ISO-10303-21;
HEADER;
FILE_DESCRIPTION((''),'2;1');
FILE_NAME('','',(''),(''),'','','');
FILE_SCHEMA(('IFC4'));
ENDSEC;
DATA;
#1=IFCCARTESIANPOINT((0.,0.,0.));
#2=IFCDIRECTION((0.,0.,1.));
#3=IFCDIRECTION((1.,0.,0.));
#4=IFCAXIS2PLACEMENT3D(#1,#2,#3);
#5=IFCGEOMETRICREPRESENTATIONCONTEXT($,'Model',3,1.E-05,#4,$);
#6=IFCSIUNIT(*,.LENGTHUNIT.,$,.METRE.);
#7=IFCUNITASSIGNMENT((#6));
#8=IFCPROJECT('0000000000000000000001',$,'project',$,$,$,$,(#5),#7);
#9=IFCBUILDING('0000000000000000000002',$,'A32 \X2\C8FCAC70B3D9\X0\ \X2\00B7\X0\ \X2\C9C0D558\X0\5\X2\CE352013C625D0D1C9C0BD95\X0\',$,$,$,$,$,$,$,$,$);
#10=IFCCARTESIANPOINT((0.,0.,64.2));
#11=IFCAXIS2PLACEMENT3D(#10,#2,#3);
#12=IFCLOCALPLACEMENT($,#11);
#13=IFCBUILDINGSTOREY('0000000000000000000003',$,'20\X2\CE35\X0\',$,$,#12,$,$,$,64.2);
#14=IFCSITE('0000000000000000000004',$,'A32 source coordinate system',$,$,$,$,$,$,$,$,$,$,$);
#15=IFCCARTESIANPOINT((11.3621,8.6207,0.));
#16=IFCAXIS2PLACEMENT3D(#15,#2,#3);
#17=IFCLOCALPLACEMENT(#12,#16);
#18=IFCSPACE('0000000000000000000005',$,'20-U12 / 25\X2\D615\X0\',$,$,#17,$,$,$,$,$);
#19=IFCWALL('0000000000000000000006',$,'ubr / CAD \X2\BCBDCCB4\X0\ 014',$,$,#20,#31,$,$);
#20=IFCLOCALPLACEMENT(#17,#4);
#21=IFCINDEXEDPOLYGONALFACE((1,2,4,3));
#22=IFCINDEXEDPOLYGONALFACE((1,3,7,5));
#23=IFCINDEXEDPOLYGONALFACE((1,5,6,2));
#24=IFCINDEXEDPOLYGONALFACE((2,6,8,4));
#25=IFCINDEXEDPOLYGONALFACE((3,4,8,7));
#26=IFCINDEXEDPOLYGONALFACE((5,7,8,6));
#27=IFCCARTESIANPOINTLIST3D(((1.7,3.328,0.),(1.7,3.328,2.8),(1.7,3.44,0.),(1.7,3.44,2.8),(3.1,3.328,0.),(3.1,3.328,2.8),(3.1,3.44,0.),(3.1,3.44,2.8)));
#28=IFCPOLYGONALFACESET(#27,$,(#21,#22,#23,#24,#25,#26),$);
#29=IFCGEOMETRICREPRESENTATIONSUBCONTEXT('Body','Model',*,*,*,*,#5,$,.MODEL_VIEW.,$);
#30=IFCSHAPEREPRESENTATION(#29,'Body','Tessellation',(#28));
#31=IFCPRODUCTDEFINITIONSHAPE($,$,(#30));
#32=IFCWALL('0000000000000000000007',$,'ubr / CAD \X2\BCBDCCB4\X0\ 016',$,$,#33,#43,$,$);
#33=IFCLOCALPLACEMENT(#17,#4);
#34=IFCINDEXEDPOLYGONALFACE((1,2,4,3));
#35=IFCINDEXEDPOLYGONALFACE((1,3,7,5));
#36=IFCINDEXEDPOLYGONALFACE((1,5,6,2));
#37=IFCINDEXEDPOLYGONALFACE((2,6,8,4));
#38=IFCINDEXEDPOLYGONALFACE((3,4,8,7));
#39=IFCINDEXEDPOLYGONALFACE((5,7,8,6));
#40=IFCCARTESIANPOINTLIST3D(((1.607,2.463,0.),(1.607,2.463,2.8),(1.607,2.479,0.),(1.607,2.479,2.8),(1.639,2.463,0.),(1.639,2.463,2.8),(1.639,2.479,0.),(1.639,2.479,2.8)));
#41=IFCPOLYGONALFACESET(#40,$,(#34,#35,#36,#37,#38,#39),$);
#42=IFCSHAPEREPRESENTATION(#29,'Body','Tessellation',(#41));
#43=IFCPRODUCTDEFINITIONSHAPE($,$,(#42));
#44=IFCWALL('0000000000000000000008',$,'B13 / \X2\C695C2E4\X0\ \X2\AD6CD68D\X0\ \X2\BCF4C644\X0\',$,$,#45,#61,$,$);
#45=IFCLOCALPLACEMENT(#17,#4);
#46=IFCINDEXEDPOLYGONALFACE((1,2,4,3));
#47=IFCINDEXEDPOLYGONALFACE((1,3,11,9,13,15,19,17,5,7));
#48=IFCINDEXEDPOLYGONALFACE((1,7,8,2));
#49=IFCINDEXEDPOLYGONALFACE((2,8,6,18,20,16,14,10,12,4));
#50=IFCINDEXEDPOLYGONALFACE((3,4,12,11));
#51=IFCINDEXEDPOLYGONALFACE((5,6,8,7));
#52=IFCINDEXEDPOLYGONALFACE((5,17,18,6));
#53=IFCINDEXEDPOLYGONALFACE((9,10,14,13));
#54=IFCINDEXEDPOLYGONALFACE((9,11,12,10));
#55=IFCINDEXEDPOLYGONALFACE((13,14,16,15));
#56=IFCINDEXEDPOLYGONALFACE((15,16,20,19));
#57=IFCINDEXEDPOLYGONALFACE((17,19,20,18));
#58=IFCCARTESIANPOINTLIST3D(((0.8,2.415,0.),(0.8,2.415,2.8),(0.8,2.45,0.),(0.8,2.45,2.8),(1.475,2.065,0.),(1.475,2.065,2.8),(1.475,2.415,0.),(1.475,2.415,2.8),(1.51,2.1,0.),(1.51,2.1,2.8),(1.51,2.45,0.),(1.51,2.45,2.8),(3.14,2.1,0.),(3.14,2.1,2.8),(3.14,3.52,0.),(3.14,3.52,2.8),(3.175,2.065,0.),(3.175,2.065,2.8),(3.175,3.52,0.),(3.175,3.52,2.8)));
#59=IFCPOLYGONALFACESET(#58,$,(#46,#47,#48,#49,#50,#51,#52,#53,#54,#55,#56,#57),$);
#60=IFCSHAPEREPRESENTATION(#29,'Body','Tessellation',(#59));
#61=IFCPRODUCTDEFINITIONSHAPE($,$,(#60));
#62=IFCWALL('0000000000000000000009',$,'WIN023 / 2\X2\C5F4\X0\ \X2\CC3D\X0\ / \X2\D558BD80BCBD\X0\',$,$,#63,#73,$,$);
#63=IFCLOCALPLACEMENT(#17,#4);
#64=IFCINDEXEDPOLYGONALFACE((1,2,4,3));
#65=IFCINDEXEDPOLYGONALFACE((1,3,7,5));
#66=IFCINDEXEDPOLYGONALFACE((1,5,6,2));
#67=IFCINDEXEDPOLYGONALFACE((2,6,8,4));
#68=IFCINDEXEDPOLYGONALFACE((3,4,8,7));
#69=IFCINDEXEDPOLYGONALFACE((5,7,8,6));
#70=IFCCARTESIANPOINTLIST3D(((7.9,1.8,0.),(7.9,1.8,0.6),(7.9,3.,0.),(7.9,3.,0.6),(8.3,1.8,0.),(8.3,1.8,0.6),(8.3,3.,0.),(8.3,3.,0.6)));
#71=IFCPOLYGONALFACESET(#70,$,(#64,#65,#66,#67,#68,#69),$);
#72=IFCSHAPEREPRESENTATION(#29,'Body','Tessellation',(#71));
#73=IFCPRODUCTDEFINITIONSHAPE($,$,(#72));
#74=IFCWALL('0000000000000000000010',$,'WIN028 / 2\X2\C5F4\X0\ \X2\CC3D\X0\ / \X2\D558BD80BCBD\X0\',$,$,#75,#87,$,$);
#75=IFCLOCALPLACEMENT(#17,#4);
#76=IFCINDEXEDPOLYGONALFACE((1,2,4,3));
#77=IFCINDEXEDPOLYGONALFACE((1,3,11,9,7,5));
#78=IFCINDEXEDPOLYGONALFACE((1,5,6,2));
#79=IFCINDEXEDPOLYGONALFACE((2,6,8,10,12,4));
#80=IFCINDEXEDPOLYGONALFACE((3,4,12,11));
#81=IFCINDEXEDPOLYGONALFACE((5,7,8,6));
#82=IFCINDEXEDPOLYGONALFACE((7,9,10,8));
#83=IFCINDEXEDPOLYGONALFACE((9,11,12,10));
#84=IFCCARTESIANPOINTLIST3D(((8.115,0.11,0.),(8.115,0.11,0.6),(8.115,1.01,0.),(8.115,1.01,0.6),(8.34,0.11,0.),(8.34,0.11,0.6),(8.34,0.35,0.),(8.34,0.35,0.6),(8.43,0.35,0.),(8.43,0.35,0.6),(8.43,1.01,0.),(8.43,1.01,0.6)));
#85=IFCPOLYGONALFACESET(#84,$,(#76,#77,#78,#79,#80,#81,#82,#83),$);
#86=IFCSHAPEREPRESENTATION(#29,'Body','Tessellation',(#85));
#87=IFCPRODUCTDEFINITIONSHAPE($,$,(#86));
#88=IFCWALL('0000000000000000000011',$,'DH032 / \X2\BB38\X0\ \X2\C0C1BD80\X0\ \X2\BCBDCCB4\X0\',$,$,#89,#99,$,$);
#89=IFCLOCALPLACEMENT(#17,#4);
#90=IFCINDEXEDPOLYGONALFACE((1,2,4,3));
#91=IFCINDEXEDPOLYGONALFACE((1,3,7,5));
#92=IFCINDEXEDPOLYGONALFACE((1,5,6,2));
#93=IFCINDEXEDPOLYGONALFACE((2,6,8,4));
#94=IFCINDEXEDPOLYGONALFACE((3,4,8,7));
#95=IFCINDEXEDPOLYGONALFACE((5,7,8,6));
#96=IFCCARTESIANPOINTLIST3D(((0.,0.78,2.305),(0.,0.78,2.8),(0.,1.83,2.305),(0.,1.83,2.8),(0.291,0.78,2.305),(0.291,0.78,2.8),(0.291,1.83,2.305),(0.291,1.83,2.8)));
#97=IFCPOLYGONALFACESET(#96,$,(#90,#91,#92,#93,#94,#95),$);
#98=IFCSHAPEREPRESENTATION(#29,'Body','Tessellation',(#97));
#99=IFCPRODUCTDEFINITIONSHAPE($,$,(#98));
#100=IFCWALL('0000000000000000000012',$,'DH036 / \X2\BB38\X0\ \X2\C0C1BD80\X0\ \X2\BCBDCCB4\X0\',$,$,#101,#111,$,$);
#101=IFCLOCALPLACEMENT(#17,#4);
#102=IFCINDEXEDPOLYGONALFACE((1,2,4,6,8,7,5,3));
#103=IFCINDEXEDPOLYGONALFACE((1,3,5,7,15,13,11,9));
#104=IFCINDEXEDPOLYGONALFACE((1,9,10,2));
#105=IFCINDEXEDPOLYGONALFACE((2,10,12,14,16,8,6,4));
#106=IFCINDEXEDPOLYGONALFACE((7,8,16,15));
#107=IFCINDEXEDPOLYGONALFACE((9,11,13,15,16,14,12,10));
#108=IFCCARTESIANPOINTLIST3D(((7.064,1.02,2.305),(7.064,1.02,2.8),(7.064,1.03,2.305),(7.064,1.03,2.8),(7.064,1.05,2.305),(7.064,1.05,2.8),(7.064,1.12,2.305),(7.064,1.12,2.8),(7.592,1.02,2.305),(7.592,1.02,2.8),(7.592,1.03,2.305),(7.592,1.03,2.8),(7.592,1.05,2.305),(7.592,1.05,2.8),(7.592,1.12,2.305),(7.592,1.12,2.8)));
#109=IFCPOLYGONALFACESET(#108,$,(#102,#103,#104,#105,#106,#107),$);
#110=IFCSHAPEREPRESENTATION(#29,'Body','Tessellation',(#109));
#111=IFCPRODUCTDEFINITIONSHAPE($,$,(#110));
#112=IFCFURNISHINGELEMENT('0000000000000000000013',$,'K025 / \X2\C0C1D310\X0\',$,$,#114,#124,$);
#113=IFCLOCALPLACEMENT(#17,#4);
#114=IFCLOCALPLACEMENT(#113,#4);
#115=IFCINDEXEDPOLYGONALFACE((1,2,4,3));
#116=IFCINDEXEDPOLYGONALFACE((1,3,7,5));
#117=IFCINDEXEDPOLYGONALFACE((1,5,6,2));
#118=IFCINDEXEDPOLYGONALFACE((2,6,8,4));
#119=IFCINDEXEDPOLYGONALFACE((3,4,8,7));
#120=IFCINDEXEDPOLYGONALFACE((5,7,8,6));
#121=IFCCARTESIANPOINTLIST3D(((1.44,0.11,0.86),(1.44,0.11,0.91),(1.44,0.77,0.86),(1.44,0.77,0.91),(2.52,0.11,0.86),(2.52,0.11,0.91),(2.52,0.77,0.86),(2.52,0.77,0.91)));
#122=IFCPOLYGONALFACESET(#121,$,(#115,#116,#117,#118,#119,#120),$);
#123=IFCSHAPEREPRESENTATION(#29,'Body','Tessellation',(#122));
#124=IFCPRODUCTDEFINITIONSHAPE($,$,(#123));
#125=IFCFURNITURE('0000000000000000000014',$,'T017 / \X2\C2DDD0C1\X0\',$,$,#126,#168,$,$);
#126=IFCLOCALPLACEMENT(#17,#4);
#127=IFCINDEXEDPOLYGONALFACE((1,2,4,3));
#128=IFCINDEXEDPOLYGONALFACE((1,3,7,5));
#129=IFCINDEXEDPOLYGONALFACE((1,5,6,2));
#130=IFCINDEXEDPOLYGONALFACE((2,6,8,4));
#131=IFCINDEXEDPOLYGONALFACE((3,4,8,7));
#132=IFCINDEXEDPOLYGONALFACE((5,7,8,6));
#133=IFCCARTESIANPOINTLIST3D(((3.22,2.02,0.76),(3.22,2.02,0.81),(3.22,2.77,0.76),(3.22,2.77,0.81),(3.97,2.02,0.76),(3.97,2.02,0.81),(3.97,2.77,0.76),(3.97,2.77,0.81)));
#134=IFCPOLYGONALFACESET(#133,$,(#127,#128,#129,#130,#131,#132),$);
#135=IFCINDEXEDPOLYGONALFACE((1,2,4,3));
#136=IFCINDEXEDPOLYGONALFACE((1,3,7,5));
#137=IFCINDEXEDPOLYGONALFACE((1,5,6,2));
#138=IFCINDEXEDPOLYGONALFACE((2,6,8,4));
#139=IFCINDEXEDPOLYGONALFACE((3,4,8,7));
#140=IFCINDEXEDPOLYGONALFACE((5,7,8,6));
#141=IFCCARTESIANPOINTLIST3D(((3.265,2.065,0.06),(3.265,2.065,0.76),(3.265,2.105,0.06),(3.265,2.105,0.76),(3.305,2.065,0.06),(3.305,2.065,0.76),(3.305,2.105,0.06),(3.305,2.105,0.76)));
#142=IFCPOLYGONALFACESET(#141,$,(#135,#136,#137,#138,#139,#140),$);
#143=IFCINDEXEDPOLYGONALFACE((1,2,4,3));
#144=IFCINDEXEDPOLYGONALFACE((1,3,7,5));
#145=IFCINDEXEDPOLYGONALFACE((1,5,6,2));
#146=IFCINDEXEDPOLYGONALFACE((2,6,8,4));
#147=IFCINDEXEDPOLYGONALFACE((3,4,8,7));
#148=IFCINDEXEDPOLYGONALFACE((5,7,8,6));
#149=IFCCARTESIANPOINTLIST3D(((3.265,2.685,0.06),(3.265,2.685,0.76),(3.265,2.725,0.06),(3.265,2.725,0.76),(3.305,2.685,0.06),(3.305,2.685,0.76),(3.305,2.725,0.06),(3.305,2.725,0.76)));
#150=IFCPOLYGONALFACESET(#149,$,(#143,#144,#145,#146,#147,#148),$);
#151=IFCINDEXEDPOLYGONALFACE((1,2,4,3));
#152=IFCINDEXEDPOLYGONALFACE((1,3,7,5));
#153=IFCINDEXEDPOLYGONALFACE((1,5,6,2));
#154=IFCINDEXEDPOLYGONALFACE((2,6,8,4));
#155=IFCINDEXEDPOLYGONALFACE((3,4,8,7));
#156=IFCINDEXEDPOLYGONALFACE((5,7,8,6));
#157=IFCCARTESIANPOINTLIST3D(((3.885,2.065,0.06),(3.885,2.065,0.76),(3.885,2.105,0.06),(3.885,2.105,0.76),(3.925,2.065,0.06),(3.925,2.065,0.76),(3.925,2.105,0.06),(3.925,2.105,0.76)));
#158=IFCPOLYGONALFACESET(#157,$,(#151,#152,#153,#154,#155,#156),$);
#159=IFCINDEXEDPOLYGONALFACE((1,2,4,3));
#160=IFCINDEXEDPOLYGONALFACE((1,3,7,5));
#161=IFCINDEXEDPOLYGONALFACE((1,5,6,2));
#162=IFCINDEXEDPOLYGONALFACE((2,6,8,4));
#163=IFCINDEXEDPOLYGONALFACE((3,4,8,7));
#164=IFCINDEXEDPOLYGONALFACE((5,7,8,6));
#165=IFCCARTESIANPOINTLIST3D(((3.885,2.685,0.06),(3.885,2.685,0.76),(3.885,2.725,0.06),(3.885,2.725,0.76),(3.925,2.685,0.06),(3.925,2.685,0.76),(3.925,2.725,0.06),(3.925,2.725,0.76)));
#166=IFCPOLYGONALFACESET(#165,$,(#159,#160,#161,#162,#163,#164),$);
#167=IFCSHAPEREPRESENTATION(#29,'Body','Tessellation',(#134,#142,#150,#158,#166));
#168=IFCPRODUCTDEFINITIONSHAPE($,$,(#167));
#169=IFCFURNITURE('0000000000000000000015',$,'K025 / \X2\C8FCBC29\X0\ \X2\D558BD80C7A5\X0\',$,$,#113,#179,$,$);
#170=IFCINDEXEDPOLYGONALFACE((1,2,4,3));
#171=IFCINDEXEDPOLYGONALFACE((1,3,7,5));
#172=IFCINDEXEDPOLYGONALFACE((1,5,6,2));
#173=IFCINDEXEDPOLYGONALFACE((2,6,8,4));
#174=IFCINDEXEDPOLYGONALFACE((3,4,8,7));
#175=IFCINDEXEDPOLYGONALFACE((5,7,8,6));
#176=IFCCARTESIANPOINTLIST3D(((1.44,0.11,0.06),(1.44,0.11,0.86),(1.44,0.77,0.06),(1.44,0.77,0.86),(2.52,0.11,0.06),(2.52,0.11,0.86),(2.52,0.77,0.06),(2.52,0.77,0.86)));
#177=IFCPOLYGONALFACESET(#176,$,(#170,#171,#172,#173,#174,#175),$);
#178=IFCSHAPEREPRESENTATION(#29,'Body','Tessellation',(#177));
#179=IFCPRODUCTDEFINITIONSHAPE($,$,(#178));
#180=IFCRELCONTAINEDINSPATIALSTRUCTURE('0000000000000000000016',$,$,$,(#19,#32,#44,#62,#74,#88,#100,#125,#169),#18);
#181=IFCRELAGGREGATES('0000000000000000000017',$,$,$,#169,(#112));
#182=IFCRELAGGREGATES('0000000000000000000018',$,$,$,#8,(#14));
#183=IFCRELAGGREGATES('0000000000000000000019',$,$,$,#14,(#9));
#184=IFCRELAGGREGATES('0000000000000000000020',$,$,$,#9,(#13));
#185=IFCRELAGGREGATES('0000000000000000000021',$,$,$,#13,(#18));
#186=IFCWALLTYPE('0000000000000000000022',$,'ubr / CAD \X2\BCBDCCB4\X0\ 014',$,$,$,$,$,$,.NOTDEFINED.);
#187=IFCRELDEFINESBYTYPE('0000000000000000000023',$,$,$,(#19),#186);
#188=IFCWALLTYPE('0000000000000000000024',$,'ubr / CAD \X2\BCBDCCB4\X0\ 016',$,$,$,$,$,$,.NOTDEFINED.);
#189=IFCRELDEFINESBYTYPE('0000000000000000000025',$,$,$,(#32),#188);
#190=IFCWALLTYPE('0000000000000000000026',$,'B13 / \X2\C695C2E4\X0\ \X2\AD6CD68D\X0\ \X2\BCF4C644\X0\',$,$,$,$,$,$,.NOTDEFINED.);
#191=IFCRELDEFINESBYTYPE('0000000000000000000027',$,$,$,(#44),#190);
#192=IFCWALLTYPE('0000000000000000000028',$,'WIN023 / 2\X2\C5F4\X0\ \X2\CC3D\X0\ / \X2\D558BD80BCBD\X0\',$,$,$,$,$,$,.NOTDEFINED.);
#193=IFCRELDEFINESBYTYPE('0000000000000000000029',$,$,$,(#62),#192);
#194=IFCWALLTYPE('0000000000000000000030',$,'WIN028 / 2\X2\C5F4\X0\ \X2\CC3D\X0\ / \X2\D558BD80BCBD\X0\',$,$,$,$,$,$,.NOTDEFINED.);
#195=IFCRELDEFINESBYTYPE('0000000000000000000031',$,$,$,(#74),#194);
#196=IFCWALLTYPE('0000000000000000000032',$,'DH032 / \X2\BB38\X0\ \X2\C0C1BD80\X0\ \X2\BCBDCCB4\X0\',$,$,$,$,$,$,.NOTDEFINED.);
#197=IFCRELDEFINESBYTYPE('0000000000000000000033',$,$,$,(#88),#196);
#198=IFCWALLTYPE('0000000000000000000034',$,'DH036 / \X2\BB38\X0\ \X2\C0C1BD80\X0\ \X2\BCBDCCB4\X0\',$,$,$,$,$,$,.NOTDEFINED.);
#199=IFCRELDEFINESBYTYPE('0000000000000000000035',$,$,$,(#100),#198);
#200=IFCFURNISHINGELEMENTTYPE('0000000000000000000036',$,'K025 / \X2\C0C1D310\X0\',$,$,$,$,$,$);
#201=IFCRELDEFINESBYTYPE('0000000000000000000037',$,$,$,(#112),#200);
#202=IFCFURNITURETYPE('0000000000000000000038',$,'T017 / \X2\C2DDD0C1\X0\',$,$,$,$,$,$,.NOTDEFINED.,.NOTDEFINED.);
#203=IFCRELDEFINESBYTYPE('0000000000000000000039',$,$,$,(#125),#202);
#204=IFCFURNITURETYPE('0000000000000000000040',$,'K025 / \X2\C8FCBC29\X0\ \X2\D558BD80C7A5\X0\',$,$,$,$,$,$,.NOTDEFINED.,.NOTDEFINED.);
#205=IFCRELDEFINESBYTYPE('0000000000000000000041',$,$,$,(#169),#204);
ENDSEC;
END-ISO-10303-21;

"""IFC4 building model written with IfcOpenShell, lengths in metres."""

from ifc_helpers import new_model, si_unit, frame, origin, origin_with_axes, place, context, subcontext, project, spatial, polyline, outline, extrude, source, transform, mapped, type_object, type_shapes, element, aggregate, save


model = new_model("IFC4")

# Units and contexts
model_context = context("Model", 3, precision=1e-05, world=origin_with_axes())
body_context = subcontext(model_context, "Body", "Model", "MODEL_VIEW")
ifc_project = project(units=[si_unit("LENGTHUNIT", "METRE")], contexts=[model_context])

# Site, building, storey, space
site = spatial("IfcSite", under=ifc_project, Name="A32 source coordinate system")
building = spatial("IfcBuilding", under=site, Name="A32 주거동 · 지하5층–옥탑지붕")
storey_placement = place(None, frame((0.0, 0.0, 64.2), z_axis=(0.0, 0.0, 1.0), x_axis=(1.0, 0.0, 0.0)))
storey = spatial("IfcBuildingStorey", under=building, at=storey_placement, Name="20층", Elevation=64.2)
space_1_placement = place(storey_placement, frame((11.3621, 8.6207, 0.0), z_axis=(0.0, 0.0, 1.0), x_axis=(1.0, 0.0, 0.0)))
space_1 = spatial("IfcSpace", under=storey, at=space_1_placement, Name="20-U12 / 25형")

# Walls
wall_type_1 = type_object("IfcWallType", Name="ubr / CAD 벽체 014", PredefinedType="NOTDEFINED")
shared_shape_1 = source(origin(), body_context, "Body", "SweptSolid", [
    extrude(outline(polyline([(3.1, 3.44), (3.1, 3.328), (1.7, 3.328), (1.7, 3.44), (3.1, 3.44)])), origin(), (0.0, 0.0, 1.0), 2.8),
])
type_shapes(wall_type_1, [shared_shape_1])
wall_1_placement = place(space_1_placement, origin_with_axes())
element("IfcWall", 1, at=wall_1_placement, inside=space_1, type_object=wall_type_1, Name="ubr / CAD 벽체 014", context=body_context, shape_type="MappedRepresentation", body=[
    mapped(shared_shape_1, transform((0.0, 0.0, 0.0), scale=1.0)),
])
wall_type_2 = type_object("IfcWallType", Name="ubr / CAD 벽체 016", PredefinedType="NOTDEFINED")
shared_shape_2 = source(origin(), body_context, "Body", "SweptSolid", [
    extrude(outline(polyline([(1.639, 2.479), (1.639, 2.463), (1.607, 2.463), (1.607, 2.479), (1.639, 2.479)])), origin(), (0.0, 0.0, 1.0), 2.8),
])
type_shapes(wall_type_2, [shared_shape_2])
wall_2_placement = place(space_1_placement, origin_with_axes())
element("IfcWall", 2, at=wall_2_placement, inside=space_1, type_object=wall_type_2, Name="ubr / CAD 벽체 016", context=body_context, shape_type="MappedRepresentation", body=[
    mapped(shared_shape_2, transform((0.0, 0.0, 0.0), scale=1.0)),
])
wall_type_3 = type_object("IfcWallType", Name="B13 / 욕실 구획 보완", PredefinedType="NOTDEFINED")
shared_shape_3 = source(origin(), body_context, "Body", "SweptSolid", [
    extrude(outline(polyline([(0.8, 2.45), (1.51, 2.45), (1.51, 2.1), (3.14, 2.1), (3.14, 3.52), (3.175, 3.52), (3.175, 2.065), (1.475, 2.065), (1.475, 2.415), (0.8, 2.415), (0.8, 2.45)])), origin(), (0.0, 0.0, 1.0), 2.8),
])
type_shapes(wall_type_3, [shared_shape_3])
wall_3_placement = place(space_1_placement, origin_with_axes())
element("IfcWall", 3, at=wall_3_placement, inside=space_1, type_object=wall_type_3, Name="B13 / 욕실 구획 보완", context=body_context, shape_type="MappedRepresentation", body=[
    mapped(shared_shape_3, transform((0.0, 0.0, 0.0), scale=1.0)),
])
wall_type_4 = type_object("IfcWallType", Name="WIN023 / 2열 창 / 하부벽", PredefinedType="NOTDEFINED")
shared_shape_4 = source(origin(), body_context, "Body", "SweptSolid", [
    extrude(outline(polyline([(7.9, 1.8), (7.9, 3.0), (8.3, 3.0), (8.3, 1.8), (7.9, 1.8)])), origin(), (0.0, 0.0, 1.0), 0.6),
])
type_shapes(wall_type_4, [shared_shape_4])
wall_4_placement = place(space_1_placement, origin_with_axes())
element("IfcWall", 4, at=wall_4_placement, inside=space_1, type_object=wall_type_4, Name="WIN023 / 2열 창 / 하부벽", context=body_context, shape_type="MappedRepresentation", body=[
    mapped(shared_shape_4, transform((0.0, 0.0, 0.0), scale=1.0)),
])
wall_type_5 = type_object("IfcWallType", Name="WIN028 / 2열 창 / 하부벽", PredefinedType="NOTDEFINED")
shared_shape_5 = source(origin(), body_context, "Body", "SweptSolid", [
    extrude(outline(polyline([(8.34, 0.35), (8.34, 0.11), (8.115, 0.11), (8.115, 1.01), (8.43, 1.01), (8.43, 0.35), (8.34, 0.35)])), origin(), (0.0, 0.0, 1.0), 0.6),
])
type_shapes(wall_type_5, [shared_shape_5])
wall_5_placement = place(space_1_placement, origin_with_axes())
element("IfcWall", 5, at=wall_5_placement, inside=space_1, type_object=wall_type_5, Name="WIN028 / 2열 창 / 하부벽", context=body_context, shape_type="MappedRepresentation", body=[
    mapped(shared_shape_5, transform((0.0, 0.0, 0.0), scale=1.0)),
])
wall_type_6 = type_object("IfcWallType", Name="DH032 / 문 상부 벽체", PredefinedType="NOTDEFINED")
shared_shape_6 = source(origin(), body_context, "Body", "SweptSolid", [
    extrude(outline(polyline([(0.0, 1.83), (0.291, 1.83), (0.291, 0.78), (0.0, 0.78), (0.0, 1.83)])), frame((0.0, 0.0, 2.305)), (0.0, 0.0, 1.0), 0.495),
])
type_shapes(wall_type_6, [shared_shape_6])
wall_6_placement = place(space_1_placement, origin_with_axes())
element("IfcWall", 6, at=wall_6_placement, inside=space_1, type_object=wall_type_6, Name="DH032 / 문 상부 벽체", context=body_context, shape_type="MappedRepresentation", body=[
    mapped(shared_shape_6, transform((0.0, 0.0, 0.0), scale=1.0)),
])
wall_type_7 = type_object("IfcWallType", Name="DH036 / 문 상부 벽체", PredefinedType="NOTDEFINED")
shared_shape_7 = source(origin(), body_context, "Body", "SweptSolid", [
    extrude(outline(polyline([(7.064, 1.03), (7.064, 1.05), (7.064, 1.12), (7.592, 1.12), (7.592, 1.05), (7.592, 1.03), (7.592, 1.02), (7.064, 1.02), (7.064, 1.03)])), frame((0.0, 0.0, 2.305)), (0.0, 0.0, 1.0), 0.495),
])
type_shapes(wall_type_7, [shared_shape_7])
wall_7_placement = place(space_1_placement, origin_with_axes())
element("IfcWall", 7, at=wall_7_placement, inside=space_1, type_object=wall_type_7, Name="DH036 / 문 상부 벽체", context=body_context, shape_type="MappedRepresentation", body=[
    mapped(shared_shape_7, transform((0.0, 0.0, 0.0), scale=1.0)),
])

# Furnishing element
furnishing_element_type_1 = type_object("IfcFurnishingElementType", Name="K025 / 상판")
shared_shape_8 = source(origin(), body_context, "Body", "SweptSolid", [
    extrude(outline(polyline([(2.52, 0.77), (2.52, 0.11), (1.44, 0.11), (1.44, 0.77), (2.52, 0.77)])), frame((0.0, 0.0, 0.86)), (0.0, 0.0, 1.0), 0.05),
])
type_shapes(furnishing_element_type_1, [shared_shape_8])
furniture_1_placement = place(space_1_placement, origin_with_axes())
furnishing_1_placement = place(furniture_1_placement, origin_with_axes())
furnishing_1 = element("IfcFurnishingElement", 8, at=furnishing_1_placement, type_object=furnishing_element_type_1, Name="K025 / 상판", context=body_context, shape_type="MappedRepresentation", body=[
    mapped(shared_shape_8, transform((0.0, 0.0, 0.0), scale=1.0)),
])

# Furniture
furniture_type_1 = type_object("IfcFurnitureType", Name="T017 / 식탁", AssemblyPlace="NOTDEFINED", PredefinedType="NOTDEFINED")
shared_shape_9 = source(origin(), body_context, "Body", "SweptSolid", [
    extrude(outline(polyline([(3.97, 2.02), (3.22, 2.02), (3.22, 2.77), (3.97, 2.77), (3.97, 2.02)])), frame((0.0, 0.0, 0.76)), (0.0, 0.0, 1.0), 0.05),
    extrude(outline(polyline([(3.265, 2.065), (3.265, 2.105), (3.305, 2.105), (3.305, 2.065), (3.265, 2.065)])), frame((0.0, 0.0, 0.06)), (0.0, 0.0, 1.0), 0.7),
    extrude(outline(polyline([(3.265, 2.685), (3.265, 2.725), (3.305, 2.725), (3.305, 2.685), (3.265, 2.685)])), frame((0.0, 0.0, 0.06)), (0.0, 0.0, 1.0), 0.7),
    extrude(outline(polyline([(3.885, 2.065), (3.885, 2.105), (3.925, 2.105), (3.925, 2.065), (3.885, 2.065)])), frame((0.0, 0.0, 0.06)), (0.0, 0.0, 1.0), 0.7),
    extrude(outline(polyline([(3.885, 2.685), (3.885, 2.725), (3.925, 2.725), (3.925, 2.685), (3.885, 2.685)])), frame((0.0, 0.0, 0.06)), (0.0, 0.0, 1.0), 0.7),
])
type_shapes(furniture_type_1, [shared_shape_9])
furniture_2_placement = place(space_1_placement, origin_with_axes())
element("IfcFurniture", 9, at=furniture_2_placement, inside=space_1, type_object=furniture_type_1, Name="T017 / 식탁", context=body_context, shape_type="MappedRepresentation", body=[
    mapped(shared_shape_9, transform((0.0, 0.0, 0.0), scale=1.0)),
])
furniture_type_2 = type_object("IfcFurnitureType", Name="K025 / 주방 하부장", AssemblyPlace="NOTDEFINED", PredefinedType="NOTDEFINED")
shared_shape_10 = source(origin(), body_context, "Body", "SweptSolid", [
    extrude(outline(polyline([(1.44, 0.77), (2.52, 0.77), (2.52, 0.11), (1.44, 0.11), (1.44, 0.77)])), frame((0.0, 0.0, 0.06)), (0.0, 0.0, 1.0), 0.8),
])
type_shapes(furniture_type_2, [shared_shape_10])
furniture_1 = element("IfcFurniture", 10, at=furniture_1_placement, inside=space_1, type_object=furniture_type_2, Name="K025 / 주방 하부장", context=body_context, shape_type="MappedRepresentation", body=[
    mapped(shared_shape_10, transform((0.0, 0.0, 0.0), scale=1.0)),
])
aggregate(furniture_1, [furnishing_1])

save(model, "model.ifc")
